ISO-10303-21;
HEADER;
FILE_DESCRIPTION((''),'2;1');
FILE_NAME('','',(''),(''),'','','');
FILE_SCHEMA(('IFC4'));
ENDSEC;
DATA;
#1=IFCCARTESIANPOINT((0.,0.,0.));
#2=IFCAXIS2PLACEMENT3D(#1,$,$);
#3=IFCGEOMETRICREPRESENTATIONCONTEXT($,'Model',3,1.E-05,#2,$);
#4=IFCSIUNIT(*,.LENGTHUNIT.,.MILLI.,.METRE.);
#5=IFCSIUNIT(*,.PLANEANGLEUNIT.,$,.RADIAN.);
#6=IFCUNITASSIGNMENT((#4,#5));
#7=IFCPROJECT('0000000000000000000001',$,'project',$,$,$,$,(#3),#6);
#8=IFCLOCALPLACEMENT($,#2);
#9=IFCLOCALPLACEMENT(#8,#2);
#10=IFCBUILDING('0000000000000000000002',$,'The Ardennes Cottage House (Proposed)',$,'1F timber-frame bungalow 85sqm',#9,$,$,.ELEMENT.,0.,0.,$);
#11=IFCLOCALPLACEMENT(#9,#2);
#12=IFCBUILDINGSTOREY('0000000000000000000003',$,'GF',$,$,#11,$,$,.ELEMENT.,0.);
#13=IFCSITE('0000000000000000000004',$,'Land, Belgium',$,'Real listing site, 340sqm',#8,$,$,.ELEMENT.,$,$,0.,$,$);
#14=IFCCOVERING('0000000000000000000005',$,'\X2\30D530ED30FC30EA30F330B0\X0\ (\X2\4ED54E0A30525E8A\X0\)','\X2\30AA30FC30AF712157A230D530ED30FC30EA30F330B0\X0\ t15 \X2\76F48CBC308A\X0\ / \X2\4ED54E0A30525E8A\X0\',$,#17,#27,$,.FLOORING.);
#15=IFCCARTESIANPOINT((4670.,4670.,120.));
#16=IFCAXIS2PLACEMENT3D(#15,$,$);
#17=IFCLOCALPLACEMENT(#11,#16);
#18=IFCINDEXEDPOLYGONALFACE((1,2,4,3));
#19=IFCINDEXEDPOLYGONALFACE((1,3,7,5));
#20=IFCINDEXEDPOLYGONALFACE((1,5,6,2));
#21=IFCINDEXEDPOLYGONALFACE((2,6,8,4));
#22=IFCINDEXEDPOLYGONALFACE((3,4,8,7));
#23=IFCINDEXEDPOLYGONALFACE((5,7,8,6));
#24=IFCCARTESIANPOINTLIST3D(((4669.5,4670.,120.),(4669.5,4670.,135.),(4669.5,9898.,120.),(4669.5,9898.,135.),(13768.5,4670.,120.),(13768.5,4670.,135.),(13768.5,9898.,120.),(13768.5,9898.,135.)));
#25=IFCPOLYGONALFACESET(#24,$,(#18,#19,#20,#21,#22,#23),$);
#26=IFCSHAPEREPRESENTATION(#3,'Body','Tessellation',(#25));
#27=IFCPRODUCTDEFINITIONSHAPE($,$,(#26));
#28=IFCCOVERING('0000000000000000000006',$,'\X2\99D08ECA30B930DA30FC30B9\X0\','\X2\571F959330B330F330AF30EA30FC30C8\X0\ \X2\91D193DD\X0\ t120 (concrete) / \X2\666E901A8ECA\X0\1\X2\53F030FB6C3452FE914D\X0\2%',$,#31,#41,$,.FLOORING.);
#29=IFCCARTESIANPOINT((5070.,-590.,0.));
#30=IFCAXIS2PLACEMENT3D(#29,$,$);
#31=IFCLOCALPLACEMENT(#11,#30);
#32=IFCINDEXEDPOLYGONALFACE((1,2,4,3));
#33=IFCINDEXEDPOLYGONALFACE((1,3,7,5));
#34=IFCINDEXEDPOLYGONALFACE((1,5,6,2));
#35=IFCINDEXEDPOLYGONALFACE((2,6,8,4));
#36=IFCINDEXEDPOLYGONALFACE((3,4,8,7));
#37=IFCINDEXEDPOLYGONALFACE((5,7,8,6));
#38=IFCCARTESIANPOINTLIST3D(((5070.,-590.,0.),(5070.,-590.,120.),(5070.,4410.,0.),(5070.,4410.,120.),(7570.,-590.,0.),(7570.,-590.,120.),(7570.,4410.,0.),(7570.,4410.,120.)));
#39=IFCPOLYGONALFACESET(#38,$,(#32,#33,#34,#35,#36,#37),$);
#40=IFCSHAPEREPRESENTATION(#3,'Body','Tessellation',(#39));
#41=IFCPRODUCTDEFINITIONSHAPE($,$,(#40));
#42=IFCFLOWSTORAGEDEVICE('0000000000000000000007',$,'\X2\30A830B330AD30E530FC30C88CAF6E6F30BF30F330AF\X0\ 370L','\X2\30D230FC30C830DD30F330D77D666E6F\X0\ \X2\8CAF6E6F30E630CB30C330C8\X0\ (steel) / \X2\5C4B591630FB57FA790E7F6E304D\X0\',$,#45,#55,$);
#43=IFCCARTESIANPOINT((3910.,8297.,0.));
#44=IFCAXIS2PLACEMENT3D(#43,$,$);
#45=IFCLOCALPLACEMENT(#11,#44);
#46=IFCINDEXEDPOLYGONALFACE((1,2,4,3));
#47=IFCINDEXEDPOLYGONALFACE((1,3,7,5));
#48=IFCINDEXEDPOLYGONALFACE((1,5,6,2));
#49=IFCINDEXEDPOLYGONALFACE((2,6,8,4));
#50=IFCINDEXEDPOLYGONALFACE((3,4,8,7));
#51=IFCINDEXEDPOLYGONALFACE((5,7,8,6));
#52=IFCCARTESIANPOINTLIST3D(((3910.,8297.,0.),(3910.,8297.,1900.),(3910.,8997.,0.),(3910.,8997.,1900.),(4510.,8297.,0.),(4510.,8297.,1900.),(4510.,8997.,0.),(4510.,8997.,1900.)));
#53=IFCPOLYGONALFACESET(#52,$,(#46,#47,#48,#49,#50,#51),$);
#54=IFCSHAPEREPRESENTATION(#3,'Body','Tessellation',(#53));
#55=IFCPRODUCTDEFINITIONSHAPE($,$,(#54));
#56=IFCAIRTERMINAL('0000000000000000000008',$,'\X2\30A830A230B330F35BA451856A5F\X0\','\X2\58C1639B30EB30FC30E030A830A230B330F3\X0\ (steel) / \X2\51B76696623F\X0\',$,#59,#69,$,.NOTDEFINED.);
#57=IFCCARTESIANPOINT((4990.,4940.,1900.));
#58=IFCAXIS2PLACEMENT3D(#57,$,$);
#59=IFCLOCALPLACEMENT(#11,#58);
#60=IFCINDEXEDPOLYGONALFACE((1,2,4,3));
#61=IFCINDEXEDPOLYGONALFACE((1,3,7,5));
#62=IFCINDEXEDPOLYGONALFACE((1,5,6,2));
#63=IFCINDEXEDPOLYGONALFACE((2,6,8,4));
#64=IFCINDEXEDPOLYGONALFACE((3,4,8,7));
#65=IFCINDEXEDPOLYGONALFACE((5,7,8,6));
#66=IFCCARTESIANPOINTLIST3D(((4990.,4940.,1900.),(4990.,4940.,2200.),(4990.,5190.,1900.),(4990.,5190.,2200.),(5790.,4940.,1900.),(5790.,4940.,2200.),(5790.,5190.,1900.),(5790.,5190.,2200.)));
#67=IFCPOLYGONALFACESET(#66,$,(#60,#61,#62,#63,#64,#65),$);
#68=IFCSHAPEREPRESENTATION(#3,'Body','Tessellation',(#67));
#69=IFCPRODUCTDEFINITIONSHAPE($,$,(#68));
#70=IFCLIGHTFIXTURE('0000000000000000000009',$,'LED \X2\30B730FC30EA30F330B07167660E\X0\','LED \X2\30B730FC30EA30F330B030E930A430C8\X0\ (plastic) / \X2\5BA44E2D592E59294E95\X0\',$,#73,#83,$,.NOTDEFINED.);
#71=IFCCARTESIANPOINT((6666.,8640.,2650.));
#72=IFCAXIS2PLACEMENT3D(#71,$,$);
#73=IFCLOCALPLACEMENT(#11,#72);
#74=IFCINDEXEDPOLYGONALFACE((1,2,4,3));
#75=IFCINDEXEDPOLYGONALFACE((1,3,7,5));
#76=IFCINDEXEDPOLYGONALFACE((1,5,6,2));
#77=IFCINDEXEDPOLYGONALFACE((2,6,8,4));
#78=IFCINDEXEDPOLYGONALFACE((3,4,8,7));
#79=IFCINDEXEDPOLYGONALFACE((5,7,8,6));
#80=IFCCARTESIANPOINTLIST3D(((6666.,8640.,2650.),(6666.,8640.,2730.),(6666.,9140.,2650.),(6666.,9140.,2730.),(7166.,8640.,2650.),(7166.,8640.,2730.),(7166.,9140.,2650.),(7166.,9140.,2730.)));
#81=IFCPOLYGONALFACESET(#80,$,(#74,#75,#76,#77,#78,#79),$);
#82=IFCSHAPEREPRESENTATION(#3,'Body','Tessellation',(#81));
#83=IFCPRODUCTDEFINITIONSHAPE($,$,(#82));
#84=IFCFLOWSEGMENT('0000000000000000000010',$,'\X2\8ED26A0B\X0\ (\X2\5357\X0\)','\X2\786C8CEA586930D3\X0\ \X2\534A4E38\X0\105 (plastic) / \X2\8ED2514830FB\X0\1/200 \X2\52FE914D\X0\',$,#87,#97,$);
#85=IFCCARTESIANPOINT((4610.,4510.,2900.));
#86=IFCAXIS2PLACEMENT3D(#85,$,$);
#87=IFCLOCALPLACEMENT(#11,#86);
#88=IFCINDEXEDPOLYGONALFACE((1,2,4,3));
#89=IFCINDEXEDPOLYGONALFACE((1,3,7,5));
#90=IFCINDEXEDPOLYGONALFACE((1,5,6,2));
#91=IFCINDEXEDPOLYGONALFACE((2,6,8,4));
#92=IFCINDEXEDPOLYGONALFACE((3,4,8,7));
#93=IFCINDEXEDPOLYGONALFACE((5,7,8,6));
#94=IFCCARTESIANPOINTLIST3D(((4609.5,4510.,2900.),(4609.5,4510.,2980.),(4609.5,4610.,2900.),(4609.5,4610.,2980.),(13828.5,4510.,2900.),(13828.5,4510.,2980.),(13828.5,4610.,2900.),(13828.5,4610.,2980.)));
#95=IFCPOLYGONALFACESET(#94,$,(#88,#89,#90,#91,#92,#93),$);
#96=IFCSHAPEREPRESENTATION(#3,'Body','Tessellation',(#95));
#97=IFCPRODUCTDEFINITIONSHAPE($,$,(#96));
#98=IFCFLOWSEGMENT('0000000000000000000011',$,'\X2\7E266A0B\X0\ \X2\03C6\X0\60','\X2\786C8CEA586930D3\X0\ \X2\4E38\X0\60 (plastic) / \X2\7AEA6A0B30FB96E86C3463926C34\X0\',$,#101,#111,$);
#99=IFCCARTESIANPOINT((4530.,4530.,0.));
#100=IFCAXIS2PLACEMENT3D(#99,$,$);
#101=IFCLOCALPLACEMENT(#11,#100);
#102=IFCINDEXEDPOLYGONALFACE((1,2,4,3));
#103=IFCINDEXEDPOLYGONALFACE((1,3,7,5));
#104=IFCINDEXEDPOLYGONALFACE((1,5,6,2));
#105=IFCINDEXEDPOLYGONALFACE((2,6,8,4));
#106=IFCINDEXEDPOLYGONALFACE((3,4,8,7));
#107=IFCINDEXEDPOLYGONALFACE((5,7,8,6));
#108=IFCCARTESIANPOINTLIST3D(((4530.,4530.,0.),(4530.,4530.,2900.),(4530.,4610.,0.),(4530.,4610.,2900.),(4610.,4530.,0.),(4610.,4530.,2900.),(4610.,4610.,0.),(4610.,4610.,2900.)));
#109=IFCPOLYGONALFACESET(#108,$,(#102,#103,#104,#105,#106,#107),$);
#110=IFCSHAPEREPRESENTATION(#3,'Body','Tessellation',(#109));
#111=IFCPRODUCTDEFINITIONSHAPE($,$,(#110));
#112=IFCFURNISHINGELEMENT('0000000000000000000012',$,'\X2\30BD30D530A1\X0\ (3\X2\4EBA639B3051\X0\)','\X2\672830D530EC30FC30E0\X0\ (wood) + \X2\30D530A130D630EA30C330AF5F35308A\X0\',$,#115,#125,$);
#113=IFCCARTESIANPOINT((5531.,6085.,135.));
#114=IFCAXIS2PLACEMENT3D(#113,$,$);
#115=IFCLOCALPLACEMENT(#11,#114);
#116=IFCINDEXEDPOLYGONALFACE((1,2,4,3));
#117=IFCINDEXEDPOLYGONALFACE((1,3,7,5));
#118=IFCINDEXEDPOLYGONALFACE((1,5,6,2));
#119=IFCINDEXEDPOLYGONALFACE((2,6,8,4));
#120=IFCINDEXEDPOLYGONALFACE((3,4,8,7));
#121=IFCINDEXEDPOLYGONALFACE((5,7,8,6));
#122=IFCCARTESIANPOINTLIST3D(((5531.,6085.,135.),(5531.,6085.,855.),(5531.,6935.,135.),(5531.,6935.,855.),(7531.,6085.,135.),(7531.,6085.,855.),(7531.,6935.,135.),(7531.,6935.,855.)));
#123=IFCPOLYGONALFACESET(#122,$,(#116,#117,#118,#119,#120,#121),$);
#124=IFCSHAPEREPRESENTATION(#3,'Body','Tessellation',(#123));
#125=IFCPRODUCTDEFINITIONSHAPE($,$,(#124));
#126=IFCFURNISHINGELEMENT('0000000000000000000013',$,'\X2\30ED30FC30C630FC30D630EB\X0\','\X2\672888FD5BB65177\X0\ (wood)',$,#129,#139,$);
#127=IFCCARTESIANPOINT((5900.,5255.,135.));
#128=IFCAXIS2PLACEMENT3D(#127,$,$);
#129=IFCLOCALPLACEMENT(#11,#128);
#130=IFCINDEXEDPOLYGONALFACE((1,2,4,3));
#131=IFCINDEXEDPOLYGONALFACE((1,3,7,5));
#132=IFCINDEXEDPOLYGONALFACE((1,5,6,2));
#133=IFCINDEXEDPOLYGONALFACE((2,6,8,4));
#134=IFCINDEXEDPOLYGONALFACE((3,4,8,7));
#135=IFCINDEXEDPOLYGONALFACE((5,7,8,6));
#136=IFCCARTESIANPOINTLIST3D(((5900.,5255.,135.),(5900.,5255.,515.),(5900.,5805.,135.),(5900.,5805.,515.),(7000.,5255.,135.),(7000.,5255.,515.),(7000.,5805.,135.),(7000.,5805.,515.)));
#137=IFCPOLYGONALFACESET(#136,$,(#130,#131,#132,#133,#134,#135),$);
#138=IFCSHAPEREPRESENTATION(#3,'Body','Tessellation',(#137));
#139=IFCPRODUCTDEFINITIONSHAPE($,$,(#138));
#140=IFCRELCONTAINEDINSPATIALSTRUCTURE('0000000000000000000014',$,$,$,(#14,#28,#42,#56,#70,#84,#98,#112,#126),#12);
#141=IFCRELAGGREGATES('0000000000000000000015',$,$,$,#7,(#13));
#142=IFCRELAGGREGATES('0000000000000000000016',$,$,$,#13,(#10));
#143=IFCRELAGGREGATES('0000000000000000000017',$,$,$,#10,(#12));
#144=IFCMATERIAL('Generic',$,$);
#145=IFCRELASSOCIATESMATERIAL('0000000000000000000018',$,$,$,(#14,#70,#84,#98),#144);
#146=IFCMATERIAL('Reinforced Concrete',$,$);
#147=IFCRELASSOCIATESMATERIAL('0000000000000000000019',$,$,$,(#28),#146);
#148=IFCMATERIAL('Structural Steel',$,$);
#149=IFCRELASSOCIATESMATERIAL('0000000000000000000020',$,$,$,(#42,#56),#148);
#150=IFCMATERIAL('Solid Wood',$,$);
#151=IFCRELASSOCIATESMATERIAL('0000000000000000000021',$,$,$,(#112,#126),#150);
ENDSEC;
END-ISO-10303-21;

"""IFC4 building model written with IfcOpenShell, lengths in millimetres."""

from ifc_helpers import new_model, si_unit, frame, frame_2d, origin, place, context, project, spatial, rectangle, extrude, material, element, save


model = new_model("IFC4")

# Units and contexts
model_context = context("Model", 3, precision=1e-05, world=origin())
ifc_project = project(units=[si_unit("LENGTHUNIT", "METRE", prefix="MILLI"), si_unit("PLANEANGLEUNIT", "RADIAN")], contexts=[model_context])

# Site, building, storey
site_placement = place(None, origin())
site = spatial("IfcSite", under=ifc_project, at=site_placement, Name="Land, Belgium", ObjectType="Real listing site, 340sqm", CompositionType="ELEMENT", RefElevation=0.0)
building_placement = place(site_placement, origin())
building = spatial("IfcBuilding", under=site, at=building_placement, Name="The Ardennes Cottage House (Proposed)", ObjectType="1F timber-frame bungalow 85sqm", CompositionType="ELEMENT", ElevationOfRefHeight=0.0, ElevationOfTerrain=0.0)
storey_placement = place(building_placement, origin())
storey = spatial("IfcBuildingStorey", under=building, at=storey_placement, Name="GF", CompositionType="ELEMENT", Elevation=0.0)

# Shared definitions
ifc_material_1 = material(Name="Solid Wood")

# Shared definitions
ifc_material_2 = material(Name="Reinforced Concrete")

# Shared definitions
ifc_material_3 = material(Name="Structural Steel")

# Coverings
ifc_material_4 = material(Name="Generic")
covering_1_placement = place(storey_placement, frame((4670.0, 4670.0, 120.0)))
element("IfcCovering", 1, at=covering_1_placement, inside=storey, material=ifc_material_4, Name="フローリング (仕上げ床)", Description="オーク無垢フローリング t15 直貼り / 仕上げ床", PredefinedType="FLOORING", context=model_context, shape_type="SweptSolid", body=[
    extrude(rectangle(XDim=9099.0, YDim=5228.0, at=frame_2d((4549.0, 2614.0))), frame((4670.0, 4670.0, 120.0)), (0.0, 0.0, 1.0), 15.0),
])
covering_2_placement = place(storey_placement, frame((5070.0, -590.0, 0.0)))
element("IfcCovering", 2, at=covering_2_placement, inside=storey, material=ifc_material_2, Name="駐車スペース", Description="土間コンクリート 金鏝 t120 (concrete) / 普通車1台・水勾配2%", PredefinedType="FLOORING", context=model_context, shape_type="SweptSolid", body=[
    extrude(rectangle(XDim=2500.0, YDim=5000.0, at=frame_2d((1250.0, 2500.0))), frame((5070.0, -590.0, 0.0)), (0.0, 0.0, 1.0), 120.0),
])

# Flow storage device
flow_storage_device_placement = place(storey_placement, frame((3910.0, 8297.0, 0.0)))
element("IfcFlowStorageDevice", 3, at=flow_storage_device_placement, inside=storey, material=ifc_material_3, Name="エコキュート貯湯タンク 370L", Description="ヒートポンプ給湯 貯湯ユニット (steel) / 屋外・基礎置き", context=model_context, shape_type="SweptSolid", body=[
    extrude(rectangle(XDim=600.0, YDim=700.0, at=frame_2d((300.0, 350.0))), frame((3910.0, 8297.0, 0.0)), (0.0, 0.0, 1.0), 1900.0),
])

# Air terminal
air_terminal_placement = place(storey_placement, frame((4990.0, 4940.0, 1900.0)))
element("IfcAirTerminal", 4, at=air_terminal_placement, inside=storey, material=ifc_material_3, Name="エアコン室内機", Description="壁掛ルームエアコン (steel) / 冷暖房", PredefinedType="NOTDEFINED", context=model_context, shape_type="SweptSolid", body=[
    extrude(rectangle(XDim=800.0, YDim=250.0, at=frame_2d((400.0, 125.0))), frame((4990.0, 4940.0, 1900.0)), (0.0, 0.0, 1.0), 300.0),
])

# Light fixture
light_fixture_placement = place(storey_placement, frame((6666.0, 8640.0, 2650.0)))
element("IfcLightFixture", 5, at=light_fixture_placement, inside=storey, material=ifc_material_4, Name="LED シーリング照明", Description="LED シーリングライト (plastic) / 室中央天井", PredefinedType="NOTDEFINED", context=model_context, shape_type="SweptSolid", body=[
    extrude(rectangle(XDim=500.0, YDim=500.0, at=frame_2d((250.0, 250.0))), frame((6666.0, 8640.0, 2650.0)), (0.0, 0.0, 1.0), 80.0),
])

# Flow segments
flow_segment_1_placement = place(storey_placement, frame((4610.0, 4510.0, 2900.0)))
element("IfcFlowSegment", 6, at=flow_segment_1_placement, inside=storey, material=ifc_material_4, Name="軒樋 (南)", Description="硬質塩ビ 半丸105 (plastic) / 軒先・1/200 勾配", context=model_context, shape_type="SweptSolid", body=[
    extrude(rectangle(XDim=9219.0, YDim=100.0, at=frame_2d((4609.0, 50.0))), frame((4610.0, 4510.0, 2900.0)), (0.0, 0.0, 1.0), 80.0),
])
flow_segment_2_placement = place(storey_placement, frame((4530.0, 4530.0, 0.0)))
element("IfcFlowSegment", 7, at=flow_segment_2_placement, inside=storey, material=ifc_material_4, Name="縦樋 φ60", Description="硬質塩ビ 丸60 (plastic) / 竪樋・雨水排水", context=model_context, shape_type="SweptSolid", body=[
    extrude(rectangle(XDim=80.0, YDim=80.0, at=frame_2d((40.0, 40.0))), frame((4530.0, 4530.0, 0.0)), (0.0, 0.0, 1.0), 2900.0),
])

# Furnishing elements
furnishing_1_placement = place(storey_placement, frame((5531.0, 6085.0, 135.0)))
element("IfcFurnishingElement", 8, at=furnishing_1_placement, inside=storey, material=ifc_material_1, Name="ソファ (3人掛け)", Description="木フレーム (wood) + ファブリック張り", context=model_context, shape_type="SweptSolid", body=[
    extrude(rectangle(XDim=2000.0, YDim=850.0, at=frame_2d((1000.0, 425.0))), frame((5531.0, 6085.0, 135.0)), (0.0, 0.0, 1.0), 720.0),
])
furnishing_2_placement = place(storey_placement, frame((5900.0, 5255.0, 135.0)))
element("IfcFurnishingElement", 9, at=furnishing_2_placement, inside=storey, material=ifc_material_1, Name="ローテーブル", Description="木製家具 (wood)", context=model_context, shape_type="SweptSolid", body=[
    extrude(rectangle(XDim=1100.0, YDim=550.0, at=frame_2d((550.0, 275.0))), frame((5900.0, 5255.0, 135.0)), (0.0, 0.0, 1.0), 380.0),
])

save(model, "model.ifc")
